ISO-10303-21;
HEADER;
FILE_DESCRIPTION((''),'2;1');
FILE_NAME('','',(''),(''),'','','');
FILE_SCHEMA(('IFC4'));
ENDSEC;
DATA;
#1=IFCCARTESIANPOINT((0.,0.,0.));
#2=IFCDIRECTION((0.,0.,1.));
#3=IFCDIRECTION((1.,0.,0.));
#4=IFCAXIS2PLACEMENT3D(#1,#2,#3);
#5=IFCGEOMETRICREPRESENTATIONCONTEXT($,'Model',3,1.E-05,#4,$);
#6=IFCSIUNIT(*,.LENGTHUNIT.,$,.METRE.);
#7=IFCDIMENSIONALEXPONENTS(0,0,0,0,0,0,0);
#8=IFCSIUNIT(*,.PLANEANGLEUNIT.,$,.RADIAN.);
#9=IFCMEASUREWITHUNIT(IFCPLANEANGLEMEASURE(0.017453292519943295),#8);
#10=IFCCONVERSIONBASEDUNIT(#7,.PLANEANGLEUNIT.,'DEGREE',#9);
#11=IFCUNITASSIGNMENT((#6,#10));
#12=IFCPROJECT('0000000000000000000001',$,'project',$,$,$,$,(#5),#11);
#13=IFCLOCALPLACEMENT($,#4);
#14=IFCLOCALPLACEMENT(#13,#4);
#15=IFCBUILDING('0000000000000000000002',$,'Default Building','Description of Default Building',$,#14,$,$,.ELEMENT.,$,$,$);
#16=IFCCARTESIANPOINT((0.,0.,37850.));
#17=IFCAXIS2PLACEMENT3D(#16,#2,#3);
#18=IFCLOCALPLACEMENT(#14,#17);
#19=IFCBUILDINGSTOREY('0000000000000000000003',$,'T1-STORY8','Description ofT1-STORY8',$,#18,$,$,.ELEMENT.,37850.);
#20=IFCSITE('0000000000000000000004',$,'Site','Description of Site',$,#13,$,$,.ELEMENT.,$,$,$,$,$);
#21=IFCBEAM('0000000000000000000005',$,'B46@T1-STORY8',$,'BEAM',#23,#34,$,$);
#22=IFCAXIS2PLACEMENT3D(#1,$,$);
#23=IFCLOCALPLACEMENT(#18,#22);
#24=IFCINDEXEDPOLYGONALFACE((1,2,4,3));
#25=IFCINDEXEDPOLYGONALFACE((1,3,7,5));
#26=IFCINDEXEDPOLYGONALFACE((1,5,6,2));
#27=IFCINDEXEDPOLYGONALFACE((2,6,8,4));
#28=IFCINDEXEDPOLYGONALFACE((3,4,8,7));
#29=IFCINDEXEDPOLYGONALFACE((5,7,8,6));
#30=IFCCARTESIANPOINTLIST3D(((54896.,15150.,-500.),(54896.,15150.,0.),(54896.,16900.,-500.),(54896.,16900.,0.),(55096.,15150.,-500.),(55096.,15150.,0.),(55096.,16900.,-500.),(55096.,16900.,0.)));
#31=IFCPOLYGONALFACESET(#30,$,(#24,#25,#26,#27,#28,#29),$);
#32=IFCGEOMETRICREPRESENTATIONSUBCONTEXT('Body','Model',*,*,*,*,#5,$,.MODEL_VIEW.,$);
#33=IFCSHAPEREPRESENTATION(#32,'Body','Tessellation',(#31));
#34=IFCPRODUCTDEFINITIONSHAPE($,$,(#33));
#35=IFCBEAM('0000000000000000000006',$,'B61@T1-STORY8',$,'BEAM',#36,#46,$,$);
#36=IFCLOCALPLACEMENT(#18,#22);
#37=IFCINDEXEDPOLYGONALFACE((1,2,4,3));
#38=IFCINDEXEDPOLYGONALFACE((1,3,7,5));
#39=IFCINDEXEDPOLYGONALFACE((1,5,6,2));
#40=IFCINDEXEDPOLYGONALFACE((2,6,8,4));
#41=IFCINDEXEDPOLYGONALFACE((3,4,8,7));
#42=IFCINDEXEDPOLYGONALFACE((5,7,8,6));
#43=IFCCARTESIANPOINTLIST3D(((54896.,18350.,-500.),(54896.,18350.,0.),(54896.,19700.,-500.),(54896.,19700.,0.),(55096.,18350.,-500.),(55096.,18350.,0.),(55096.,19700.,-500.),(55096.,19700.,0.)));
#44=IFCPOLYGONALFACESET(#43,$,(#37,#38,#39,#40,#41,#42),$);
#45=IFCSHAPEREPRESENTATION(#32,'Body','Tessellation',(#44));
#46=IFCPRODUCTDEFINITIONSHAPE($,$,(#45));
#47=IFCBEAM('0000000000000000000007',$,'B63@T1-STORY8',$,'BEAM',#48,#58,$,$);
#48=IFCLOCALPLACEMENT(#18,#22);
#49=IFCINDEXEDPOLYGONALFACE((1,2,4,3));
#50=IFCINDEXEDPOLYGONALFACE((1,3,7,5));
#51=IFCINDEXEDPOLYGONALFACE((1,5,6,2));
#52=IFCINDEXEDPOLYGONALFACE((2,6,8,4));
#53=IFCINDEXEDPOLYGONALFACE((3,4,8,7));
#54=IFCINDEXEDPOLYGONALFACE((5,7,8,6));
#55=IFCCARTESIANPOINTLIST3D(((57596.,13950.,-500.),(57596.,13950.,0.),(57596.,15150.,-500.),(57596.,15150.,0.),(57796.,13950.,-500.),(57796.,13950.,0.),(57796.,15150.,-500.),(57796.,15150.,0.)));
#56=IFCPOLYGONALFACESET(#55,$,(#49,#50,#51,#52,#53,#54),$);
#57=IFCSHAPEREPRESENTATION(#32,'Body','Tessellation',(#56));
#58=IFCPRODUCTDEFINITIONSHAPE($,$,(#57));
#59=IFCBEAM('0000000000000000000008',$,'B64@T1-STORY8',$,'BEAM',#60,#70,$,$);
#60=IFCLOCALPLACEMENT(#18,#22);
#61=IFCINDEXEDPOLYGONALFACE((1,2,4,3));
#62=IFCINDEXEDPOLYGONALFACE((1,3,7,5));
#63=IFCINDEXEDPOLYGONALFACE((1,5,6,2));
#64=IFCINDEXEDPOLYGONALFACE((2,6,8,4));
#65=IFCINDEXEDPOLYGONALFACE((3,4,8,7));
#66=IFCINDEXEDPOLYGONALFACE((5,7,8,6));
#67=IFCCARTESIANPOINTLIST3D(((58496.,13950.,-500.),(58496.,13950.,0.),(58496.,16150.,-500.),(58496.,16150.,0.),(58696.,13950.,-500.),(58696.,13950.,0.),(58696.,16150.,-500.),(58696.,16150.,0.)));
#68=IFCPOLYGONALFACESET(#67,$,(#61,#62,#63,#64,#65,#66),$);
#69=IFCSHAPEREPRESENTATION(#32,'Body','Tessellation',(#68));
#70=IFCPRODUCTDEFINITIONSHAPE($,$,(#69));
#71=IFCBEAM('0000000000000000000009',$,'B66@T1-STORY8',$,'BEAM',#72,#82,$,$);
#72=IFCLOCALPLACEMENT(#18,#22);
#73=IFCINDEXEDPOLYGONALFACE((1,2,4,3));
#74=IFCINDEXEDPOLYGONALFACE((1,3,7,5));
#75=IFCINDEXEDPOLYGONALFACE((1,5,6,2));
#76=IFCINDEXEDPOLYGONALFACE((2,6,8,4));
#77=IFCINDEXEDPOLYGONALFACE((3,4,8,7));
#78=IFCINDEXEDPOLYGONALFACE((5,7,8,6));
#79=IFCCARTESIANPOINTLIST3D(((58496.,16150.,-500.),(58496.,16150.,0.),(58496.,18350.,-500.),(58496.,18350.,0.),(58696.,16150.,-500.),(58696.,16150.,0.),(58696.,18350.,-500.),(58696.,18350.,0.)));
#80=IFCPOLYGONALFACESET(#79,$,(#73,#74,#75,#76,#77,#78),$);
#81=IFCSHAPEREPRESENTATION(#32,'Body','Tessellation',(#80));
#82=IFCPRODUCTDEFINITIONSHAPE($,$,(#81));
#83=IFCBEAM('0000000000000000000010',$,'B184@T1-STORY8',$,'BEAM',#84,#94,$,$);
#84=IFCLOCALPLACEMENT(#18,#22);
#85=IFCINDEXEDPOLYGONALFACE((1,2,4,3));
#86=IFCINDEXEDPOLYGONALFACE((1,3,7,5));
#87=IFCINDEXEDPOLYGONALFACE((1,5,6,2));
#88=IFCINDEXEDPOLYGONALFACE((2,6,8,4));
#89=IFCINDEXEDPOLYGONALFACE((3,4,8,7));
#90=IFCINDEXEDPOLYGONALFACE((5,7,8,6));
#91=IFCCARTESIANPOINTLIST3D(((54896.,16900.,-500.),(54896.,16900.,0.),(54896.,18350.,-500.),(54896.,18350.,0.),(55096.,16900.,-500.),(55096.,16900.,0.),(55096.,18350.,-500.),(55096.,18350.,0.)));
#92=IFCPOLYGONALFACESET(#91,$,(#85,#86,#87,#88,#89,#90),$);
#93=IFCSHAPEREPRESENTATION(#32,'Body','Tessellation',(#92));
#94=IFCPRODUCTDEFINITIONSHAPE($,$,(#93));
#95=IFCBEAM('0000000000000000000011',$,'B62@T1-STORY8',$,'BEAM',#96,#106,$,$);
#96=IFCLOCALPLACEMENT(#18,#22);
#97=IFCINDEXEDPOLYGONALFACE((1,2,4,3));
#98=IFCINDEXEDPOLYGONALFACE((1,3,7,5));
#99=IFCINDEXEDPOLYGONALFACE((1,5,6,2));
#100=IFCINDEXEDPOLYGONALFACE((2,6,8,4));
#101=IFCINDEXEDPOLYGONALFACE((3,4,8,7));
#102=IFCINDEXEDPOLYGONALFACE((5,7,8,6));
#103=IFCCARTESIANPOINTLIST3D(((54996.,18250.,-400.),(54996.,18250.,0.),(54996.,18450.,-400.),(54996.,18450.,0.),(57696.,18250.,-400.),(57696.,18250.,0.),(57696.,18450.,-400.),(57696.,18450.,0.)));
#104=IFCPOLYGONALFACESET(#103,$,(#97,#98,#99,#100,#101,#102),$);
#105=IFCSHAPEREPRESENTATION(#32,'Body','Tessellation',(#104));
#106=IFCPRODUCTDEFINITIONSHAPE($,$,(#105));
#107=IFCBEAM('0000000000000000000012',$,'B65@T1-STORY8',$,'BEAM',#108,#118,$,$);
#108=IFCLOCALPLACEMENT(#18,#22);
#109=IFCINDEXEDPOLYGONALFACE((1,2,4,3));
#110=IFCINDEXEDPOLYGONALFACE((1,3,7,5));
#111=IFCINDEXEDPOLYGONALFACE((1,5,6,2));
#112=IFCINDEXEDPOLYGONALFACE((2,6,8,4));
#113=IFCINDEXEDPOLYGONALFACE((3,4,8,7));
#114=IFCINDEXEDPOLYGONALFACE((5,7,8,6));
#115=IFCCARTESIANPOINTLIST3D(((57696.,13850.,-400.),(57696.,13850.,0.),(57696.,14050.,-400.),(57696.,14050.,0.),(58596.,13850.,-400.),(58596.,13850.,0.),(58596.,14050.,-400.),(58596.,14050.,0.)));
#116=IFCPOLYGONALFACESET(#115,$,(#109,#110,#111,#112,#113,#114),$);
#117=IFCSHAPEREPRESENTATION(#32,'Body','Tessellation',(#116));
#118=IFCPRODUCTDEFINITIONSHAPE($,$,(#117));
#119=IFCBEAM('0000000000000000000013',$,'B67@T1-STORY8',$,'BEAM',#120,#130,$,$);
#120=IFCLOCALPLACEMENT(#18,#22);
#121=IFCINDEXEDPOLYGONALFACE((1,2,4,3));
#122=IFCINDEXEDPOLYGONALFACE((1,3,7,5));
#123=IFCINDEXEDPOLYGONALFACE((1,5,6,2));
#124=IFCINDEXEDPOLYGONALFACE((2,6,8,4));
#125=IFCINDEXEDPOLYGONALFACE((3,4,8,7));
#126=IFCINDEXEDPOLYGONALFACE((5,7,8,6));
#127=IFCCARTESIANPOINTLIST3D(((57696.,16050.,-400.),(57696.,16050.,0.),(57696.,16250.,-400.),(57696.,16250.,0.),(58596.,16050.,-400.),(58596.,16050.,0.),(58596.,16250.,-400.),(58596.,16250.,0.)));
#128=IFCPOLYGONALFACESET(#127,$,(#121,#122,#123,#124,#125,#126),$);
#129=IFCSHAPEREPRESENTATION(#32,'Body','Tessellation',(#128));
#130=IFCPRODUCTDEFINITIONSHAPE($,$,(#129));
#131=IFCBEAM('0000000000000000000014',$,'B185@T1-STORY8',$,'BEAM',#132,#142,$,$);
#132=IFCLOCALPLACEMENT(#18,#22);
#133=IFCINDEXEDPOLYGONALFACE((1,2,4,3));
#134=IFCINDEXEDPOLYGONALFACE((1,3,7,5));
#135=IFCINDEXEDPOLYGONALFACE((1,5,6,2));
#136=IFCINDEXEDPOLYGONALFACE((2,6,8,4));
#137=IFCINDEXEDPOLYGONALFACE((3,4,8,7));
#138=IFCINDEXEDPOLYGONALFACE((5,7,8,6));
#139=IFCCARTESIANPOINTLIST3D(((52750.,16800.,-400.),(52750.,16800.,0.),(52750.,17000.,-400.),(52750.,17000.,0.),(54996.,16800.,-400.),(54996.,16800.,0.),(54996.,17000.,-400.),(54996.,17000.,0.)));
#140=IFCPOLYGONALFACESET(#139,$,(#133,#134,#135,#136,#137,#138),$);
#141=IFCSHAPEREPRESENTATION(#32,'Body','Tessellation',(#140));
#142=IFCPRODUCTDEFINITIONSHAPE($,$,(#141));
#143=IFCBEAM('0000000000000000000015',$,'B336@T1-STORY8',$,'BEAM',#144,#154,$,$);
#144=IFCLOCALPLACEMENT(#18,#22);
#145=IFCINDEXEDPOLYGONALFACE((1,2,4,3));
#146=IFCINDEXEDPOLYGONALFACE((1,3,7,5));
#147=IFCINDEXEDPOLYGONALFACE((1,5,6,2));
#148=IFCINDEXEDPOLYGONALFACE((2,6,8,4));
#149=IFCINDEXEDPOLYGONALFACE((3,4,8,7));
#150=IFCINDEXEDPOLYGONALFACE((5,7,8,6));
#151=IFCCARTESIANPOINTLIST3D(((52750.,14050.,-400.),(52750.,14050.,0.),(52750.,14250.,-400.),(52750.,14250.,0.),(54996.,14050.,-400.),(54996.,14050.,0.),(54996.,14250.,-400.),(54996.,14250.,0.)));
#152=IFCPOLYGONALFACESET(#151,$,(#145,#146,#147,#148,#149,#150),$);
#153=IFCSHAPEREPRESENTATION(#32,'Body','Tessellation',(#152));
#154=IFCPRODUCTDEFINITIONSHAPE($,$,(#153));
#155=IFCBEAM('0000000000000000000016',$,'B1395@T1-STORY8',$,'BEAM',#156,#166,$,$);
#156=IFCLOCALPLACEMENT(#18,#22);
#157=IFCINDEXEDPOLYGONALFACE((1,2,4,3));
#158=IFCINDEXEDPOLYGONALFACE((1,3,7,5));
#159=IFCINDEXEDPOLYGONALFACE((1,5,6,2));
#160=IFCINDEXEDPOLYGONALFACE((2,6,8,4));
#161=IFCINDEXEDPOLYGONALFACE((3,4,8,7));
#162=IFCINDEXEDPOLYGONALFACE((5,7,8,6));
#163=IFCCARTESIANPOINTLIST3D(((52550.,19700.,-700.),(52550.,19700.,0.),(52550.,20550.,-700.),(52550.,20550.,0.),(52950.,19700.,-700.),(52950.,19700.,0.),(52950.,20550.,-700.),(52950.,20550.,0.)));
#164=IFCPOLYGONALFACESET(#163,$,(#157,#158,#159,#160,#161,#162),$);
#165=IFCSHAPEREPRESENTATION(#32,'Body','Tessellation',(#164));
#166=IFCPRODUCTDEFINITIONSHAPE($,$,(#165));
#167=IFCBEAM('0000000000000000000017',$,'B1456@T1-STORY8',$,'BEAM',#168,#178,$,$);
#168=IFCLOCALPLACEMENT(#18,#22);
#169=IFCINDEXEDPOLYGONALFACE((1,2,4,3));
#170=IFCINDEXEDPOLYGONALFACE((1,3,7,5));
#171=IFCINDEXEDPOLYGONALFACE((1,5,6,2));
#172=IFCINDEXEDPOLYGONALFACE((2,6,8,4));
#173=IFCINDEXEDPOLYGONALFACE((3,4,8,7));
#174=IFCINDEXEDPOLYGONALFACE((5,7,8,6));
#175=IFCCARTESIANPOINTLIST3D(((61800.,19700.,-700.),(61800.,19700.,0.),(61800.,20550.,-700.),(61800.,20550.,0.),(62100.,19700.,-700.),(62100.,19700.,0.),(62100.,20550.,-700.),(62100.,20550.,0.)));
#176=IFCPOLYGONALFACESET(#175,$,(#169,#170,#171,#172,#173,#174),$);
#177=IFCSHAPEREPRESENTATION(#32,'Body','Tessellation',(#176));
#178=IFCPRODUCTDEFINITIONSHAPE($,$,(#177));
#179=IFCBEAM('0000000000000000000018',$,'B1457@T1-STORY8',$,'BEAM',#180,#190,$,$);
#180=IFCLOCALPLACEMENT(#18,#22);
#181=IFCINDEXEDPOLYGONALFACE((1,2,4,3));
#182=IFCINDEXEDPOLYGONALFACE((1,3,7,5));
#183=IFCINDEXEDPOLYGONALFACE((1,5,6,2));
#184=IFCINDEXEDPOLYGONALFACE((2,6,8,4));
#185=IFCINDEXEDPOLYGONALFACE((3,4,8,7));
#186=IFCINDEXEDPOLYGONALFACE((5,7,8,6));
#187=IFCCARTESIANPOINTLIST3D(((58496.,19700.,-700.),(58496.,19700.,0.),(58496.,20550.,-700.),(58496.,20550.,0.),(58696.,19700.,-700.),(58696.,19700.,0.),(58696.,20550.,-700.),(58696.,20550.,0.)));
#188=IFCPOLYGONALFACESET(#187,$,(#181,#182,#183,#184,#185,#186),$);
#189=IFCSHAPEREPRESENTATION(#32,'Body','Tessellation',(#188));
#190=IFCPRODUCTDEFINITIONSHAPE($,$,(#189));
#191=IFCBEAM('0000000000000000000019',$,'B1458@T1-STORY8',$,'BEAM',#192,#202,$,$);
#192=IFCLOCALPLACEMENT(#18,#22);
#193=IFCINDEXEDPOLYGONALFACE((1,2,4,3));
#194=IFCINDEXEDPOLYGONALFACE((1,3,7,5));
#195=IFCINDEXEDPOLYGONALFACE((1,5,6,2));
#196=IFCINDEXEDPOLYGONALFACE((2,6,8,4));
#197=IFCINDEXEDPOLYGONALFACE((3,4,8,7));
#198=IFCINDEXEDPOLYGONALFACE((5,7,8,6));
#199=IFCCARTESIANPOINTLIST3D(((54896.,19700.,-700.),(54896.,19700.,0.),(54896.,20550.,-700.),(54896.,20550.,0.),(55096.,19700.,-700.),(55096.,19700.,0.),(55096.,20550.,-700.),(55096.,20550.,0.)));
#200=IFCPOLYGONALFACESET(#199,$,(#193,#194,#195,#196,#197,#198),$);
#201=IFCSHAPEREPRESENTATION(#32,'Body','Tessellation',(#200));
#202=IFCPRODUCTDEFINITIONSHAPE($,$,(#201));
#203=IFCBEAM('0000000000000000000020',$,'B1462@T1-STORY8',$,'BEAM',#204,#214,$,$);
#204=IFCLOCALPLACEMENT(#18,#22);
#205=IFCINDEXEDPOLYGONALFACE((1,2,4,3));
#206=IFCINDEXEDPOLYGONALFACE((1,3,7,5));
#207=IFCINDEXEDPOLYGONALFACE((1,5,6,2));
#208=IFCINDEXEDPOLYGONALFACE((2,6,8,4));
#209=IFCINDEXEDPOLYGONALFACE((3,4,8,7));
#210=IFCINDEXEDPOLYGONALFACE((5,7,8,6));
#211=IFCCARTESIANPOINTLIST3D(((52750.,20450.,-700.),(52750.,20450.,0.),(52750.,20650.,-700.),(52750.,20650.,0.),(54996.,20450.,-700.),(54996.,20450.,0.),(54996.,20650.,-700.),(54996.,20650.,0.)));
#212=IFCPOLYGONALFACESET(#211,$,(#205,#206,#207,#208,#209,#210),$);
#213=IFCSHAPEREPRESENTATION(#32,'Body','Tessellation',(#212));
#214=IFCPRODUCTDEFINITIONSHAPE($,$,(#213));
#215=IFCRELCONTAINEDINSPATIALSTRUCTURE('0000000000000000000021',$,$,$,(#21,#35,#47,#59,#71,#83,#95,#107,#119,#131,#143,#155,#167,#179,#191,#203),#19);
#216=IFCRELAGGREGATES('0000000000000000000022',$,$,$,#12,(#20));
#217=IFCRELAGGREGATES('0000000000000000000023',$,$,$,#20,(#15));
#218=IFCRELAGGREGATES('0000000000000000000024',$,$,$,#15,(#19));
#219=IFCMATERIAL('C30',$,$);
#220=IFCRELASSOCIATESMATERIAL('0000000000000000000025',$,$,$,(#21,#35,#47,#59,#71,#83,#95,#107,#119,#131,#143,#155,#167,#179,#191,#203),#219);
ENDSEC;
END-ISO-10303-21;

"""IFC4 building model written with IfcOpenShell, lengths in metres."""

from ifc_helpers import new_model, entity, si_unit, converted_unit, frame, origin_with_axes, place, context, subcontext, project, spatial, rectangle, extrude, material, element, save


model = new_model("IFC4")

# Units and contexts
model_context = context("Model", 3, precision=1e-05, world=origin_with_axes())
body_context = subcontext(model_context, "Body", "Model", "MODEL_VIEW")
ifc_project = project(units=[si_unit("LENGTHUNIT", "METRE"), converted_unit("PLANEANGLEUNIT", "DEGREE", entity("IfcPlaneAngleMeasure", 0.017453292519943295), si_unit("PLANEANGLEUNIT", "RADIAN"), dimensions=[0, 0, 0, 0, 0, 0, 0])], contexts=[model_context])

# Site, building, storey
site_placement = place(None, origin_with_axes())
site = spatial("IfcSite", under=ifc_project, at=site_placement, Name="Site", Description="Description of Site", CompositionType="ELEMENT")
building_placement = place(site_placement, origin_with_axes())
building = spatial("IfcBuilding", under=site, at=building_placement, Name="Default Building", Description="Description of Default Building", CompositionType="ELEMENT")
storey_placement = place(building_placement, frame((0.0, 0.0, 37850.0), z_axis=(0.0, 0.0, 1.0), x_axis=(1.0, 0.0, 0.0)))
storey = spatial("IfcBuildingStorey", under=building, at=storey_placement, Name="T1-STORY8", Description="Description ofT1-STORY8", CompositionType="ELEMENT", Elevation=37850.0)

# Beams
ifc_material_1 = material(Name="C30")
beam_1_placement = place(storey_placement, frame((54996.0, 15150.0, -250.0), z_axis=(0.0, 1.0, 0.0), x_axis=(-1.0, 0.0, 0.0)))
element("IfcBeam", 1, at=beam_1_placement, inside=storey, material=ifc_material_1, Name="B46@T1-STORY8", ObjectType="BEAM", context=body_context, shape_type="SweptSolid", body=[
    extrude(rectangle(XDim=200.0, YDim=500.0), origin_with_axes(), (0.0, 0.0, 1.0), 1750.0),
])
beam_2_placement = place(storey_placement, frame((54996.0, 18350.0, -250.0), z_axis=(0.0, 1.0, 0.0), x_axis=(-1.0, 0.0, 0.0)))
element("IfcBeam", 2, at=beam_2_placement, inside=storey, material=ifc_material_1, Name="B61@T1-STORY8", ObjectType="BEAM", context=body_context, shape_type="SweptSolid", body=[
    extrude(rectangle(XDim=200.0, YDim=500.0), origin_with_axes(), (0.0, 0.0, 1.0), 1350.0),
])
beam_3_placement = place(storey_placement, frame((57696.0, 13950.0, -250.0), z_axis=(0.0, 1.0, 0.0), x_axis=(-1.0, 0.0, 0.0)))
element("IfcBeam", 3, at=beam_3_placement, inside=storey, material=ifc_material_1, Name="B63@T1-STORY8", ObjectType="BEAM", context=body_context, shape_type="SweptSolid", body=[
    extrude(rectangle(XDim=200.0, YDim=500.0), origin_with_axes(), (0.0, 0.0, 1.0), 1200.0),
])
for number, where, z_axis, x_axis, name in (
    (4, (58596.0, 13950.0, -250.0), (0.0, 1.0, 0.0), (-1.0, 0.0, 0.0), "B64@T1-STORY8"),
    (5, (58596.0, 16150.0, -250.0), (0.0, 1.0, 0.0), (-1.0, 0.0, 0.0), "B66@T1-STORY8"),
):
    element("IfcBeam", number, at=place(storey_placement, frame(where, z_axis=z_axis, x_axis=x_axis)), inside=storey, material=ifc_material_1, Name=name, ObjectType="BEAM", context=body_context, shape_type="SweptSolid", body=[
        extrude(rectangle(XDim=200.0, YDim=500.0), origin_with_axes(), (0.0, 0.0, 1.0), 2200.0),
    ])
beam_4_placement = place(storey_placement, frame((54996.0, 16900.0, -250.0), z_axis=(0.0, 1.0, 0.0), x_axis=(-1.0, 0.0, 0.0)))
element("IfcBeam", 6, at=beam_4_placement, inside=storey, material=ifc_material_1, Name="B184@T1-STORY8", ObjectType="BEAM", context=body_context, shape_type="SweptSolid", body=[
    extrude(rectangle(XDim=200.0, YDim=500.0), origin_with_axes(), (0.0, 0.0, 1.0), 1450.0),
])
beam_5_placement = place(storey_placement, frame((54996.0, 18350.0, -200.0), z_axis=(1.0, 0.0, 0.0), x_axis=(0.0, 1.0, 0.0)))
element("IfcBeam", 7, at=beam_5_placement, inside=storey, material=ifc_material_1, Name="B62@T1-STORY8", ObjectType="BEAM", context=body_context, shape_type="SweptSolid", body=[
    extrude(rectangle(XDim=200.0, YDim=400.0), origin_with_axes(), (0.0, 0.0, 1.0), 2700.0),
])
for number, where, z_axis, x_axis, name in (
    (8, (57696.0, 13950.0, -200.0), (1.0, 0.0, 0.0), (0.0, 1.0, 0.0), "B65@T1-STORY8"),
    (9, (57696.0, 16150.0, -200.0), (1.0, 0.0, 0.0), (0.0, 1.0, 0.0), "B67@T1-STORY8"),
):
    element("IfcBeam", number, at=place(storey_placement, frame(where, z_axis=z_axis, x_axis=x_axis)), inside=storey, material=ifc_material_1, Name=name, ObjectType="BEAM", context=body_context, shape_type="SweptSolid", body=[
        extrude(rectangle(XDim=200.0, YDim=400.0), origin_with_axes(), (0.0, 0.0, 1.0), 900.0),
    ])
for number, where, z_axis, x_axis, name in (
    (10, (52750.0, 16900.0, -200.0), (1.0, 0.0, 0.0), (0.0, 1.0, 0.0), "B185@T1-STORY8"),
    (11, (52750.0, 14150.0, -200.0), (1.0, 0.0, 0.0), (0.0, 1.0, 0.0), "B336@T1-STORY8"),
):
    element("IfcBeam", number, at=place(storey_placement, frame(where, z_axis=z_axis, x_axis=x_axis)), inside=storey, material=ifc_material_1, Name=name, ObjectType="BEAM", context=body_context, shape_type="SweptSolid", body=[
        extrude(rectangle(XDim=200.0, YDim=400.0), origin_with_axes(), (0.0, 0.0, 1.0), 2246.0),
    ])
beam_6_placement = place(storey_placement, frame((52750.0, 19700.0, -350.0), z_axis=(0.0, 1.0, 0.0), x_axis=(-1.0, 0.0, 0.0)))
element("IfcBeam", 12, at=beam_6_placement, inside=storey, material=ifc_material_1, Name="B1395@T1-STORY8", ObjectType="BEAM", context=body_context, shape_type="SweptSolid", body=[
    extrude(rectangle(XDim=400.0, YDim=700.0), origin_with_axes(), (0.0, 0.0, 1.0), 850.0),
])
beam_7_placement = place(storey_placement, frame((61950.0, 19700.0, -350.0), z_axis=(0.0, 1.0, 0.0), x_axis=(-1.0, 0.0, 0.0)))
element("IfcBeam", 13, at=beam_7_placement, inside=storey, material=ifc_material_1, Name="B1456@T1-STORY8", ObjectType="BEAM", context=body_context, shape_type="SweptSolid", body=[
    extrude(rectangle(XDim=300.0, YDim=700.0), origin_with_axes(), (0.0, 0.0, 1.0), 850.0),
])
for number, where, z_axis, x_axis, name in (
    (14, (58596.0, 19700.0, -350.0), (0.0, 1.0, 0.0), (-1.0, 0.0, 0.0), "B1457@T1-STORY8"),
    (15, (54996.0, 19700.0, -350.0), (0.0, 1.0, 0.0), (-1.0, 0.0, 0.0), "B1458@T1-STORY8"),
):
    element("IfcBeam", number, at=place(storey_placement, frame(where, z_axis=z_axis, x_axis=x_axis)), inside=storey, material=ifc_material_1, Name=name, ObjectType="BEAM", context=body_context, shape_type="SweptSolid", body=[
        extrude(rectangle(XDim=200.0, YDim=700.0), origin_with_axes(), (0.0, 0.0, 1.0), 850.0),
    ])
beam_8_placement = place(storey_placement, frame((52750.0, 20550.0, -350.0), z_axis=(1.0, 0.0, 0.0), x_axis=(0.0, 1.0, 0.0)))
element("IfcBeam", 16, at=beam_8_placement, inside=storey, material=ifc_material_1, Name="B1462@T1-STORY8", ObjectType="BEAM", context=body_context, shape_type="SweptSolid", body=[
    extrude(rectangle(XDim=200.0, YDim=700.0), origin_with_axes(), (0.0, 0.0, 1.0), 2246.0),
])

save(model, "model.ifc")
